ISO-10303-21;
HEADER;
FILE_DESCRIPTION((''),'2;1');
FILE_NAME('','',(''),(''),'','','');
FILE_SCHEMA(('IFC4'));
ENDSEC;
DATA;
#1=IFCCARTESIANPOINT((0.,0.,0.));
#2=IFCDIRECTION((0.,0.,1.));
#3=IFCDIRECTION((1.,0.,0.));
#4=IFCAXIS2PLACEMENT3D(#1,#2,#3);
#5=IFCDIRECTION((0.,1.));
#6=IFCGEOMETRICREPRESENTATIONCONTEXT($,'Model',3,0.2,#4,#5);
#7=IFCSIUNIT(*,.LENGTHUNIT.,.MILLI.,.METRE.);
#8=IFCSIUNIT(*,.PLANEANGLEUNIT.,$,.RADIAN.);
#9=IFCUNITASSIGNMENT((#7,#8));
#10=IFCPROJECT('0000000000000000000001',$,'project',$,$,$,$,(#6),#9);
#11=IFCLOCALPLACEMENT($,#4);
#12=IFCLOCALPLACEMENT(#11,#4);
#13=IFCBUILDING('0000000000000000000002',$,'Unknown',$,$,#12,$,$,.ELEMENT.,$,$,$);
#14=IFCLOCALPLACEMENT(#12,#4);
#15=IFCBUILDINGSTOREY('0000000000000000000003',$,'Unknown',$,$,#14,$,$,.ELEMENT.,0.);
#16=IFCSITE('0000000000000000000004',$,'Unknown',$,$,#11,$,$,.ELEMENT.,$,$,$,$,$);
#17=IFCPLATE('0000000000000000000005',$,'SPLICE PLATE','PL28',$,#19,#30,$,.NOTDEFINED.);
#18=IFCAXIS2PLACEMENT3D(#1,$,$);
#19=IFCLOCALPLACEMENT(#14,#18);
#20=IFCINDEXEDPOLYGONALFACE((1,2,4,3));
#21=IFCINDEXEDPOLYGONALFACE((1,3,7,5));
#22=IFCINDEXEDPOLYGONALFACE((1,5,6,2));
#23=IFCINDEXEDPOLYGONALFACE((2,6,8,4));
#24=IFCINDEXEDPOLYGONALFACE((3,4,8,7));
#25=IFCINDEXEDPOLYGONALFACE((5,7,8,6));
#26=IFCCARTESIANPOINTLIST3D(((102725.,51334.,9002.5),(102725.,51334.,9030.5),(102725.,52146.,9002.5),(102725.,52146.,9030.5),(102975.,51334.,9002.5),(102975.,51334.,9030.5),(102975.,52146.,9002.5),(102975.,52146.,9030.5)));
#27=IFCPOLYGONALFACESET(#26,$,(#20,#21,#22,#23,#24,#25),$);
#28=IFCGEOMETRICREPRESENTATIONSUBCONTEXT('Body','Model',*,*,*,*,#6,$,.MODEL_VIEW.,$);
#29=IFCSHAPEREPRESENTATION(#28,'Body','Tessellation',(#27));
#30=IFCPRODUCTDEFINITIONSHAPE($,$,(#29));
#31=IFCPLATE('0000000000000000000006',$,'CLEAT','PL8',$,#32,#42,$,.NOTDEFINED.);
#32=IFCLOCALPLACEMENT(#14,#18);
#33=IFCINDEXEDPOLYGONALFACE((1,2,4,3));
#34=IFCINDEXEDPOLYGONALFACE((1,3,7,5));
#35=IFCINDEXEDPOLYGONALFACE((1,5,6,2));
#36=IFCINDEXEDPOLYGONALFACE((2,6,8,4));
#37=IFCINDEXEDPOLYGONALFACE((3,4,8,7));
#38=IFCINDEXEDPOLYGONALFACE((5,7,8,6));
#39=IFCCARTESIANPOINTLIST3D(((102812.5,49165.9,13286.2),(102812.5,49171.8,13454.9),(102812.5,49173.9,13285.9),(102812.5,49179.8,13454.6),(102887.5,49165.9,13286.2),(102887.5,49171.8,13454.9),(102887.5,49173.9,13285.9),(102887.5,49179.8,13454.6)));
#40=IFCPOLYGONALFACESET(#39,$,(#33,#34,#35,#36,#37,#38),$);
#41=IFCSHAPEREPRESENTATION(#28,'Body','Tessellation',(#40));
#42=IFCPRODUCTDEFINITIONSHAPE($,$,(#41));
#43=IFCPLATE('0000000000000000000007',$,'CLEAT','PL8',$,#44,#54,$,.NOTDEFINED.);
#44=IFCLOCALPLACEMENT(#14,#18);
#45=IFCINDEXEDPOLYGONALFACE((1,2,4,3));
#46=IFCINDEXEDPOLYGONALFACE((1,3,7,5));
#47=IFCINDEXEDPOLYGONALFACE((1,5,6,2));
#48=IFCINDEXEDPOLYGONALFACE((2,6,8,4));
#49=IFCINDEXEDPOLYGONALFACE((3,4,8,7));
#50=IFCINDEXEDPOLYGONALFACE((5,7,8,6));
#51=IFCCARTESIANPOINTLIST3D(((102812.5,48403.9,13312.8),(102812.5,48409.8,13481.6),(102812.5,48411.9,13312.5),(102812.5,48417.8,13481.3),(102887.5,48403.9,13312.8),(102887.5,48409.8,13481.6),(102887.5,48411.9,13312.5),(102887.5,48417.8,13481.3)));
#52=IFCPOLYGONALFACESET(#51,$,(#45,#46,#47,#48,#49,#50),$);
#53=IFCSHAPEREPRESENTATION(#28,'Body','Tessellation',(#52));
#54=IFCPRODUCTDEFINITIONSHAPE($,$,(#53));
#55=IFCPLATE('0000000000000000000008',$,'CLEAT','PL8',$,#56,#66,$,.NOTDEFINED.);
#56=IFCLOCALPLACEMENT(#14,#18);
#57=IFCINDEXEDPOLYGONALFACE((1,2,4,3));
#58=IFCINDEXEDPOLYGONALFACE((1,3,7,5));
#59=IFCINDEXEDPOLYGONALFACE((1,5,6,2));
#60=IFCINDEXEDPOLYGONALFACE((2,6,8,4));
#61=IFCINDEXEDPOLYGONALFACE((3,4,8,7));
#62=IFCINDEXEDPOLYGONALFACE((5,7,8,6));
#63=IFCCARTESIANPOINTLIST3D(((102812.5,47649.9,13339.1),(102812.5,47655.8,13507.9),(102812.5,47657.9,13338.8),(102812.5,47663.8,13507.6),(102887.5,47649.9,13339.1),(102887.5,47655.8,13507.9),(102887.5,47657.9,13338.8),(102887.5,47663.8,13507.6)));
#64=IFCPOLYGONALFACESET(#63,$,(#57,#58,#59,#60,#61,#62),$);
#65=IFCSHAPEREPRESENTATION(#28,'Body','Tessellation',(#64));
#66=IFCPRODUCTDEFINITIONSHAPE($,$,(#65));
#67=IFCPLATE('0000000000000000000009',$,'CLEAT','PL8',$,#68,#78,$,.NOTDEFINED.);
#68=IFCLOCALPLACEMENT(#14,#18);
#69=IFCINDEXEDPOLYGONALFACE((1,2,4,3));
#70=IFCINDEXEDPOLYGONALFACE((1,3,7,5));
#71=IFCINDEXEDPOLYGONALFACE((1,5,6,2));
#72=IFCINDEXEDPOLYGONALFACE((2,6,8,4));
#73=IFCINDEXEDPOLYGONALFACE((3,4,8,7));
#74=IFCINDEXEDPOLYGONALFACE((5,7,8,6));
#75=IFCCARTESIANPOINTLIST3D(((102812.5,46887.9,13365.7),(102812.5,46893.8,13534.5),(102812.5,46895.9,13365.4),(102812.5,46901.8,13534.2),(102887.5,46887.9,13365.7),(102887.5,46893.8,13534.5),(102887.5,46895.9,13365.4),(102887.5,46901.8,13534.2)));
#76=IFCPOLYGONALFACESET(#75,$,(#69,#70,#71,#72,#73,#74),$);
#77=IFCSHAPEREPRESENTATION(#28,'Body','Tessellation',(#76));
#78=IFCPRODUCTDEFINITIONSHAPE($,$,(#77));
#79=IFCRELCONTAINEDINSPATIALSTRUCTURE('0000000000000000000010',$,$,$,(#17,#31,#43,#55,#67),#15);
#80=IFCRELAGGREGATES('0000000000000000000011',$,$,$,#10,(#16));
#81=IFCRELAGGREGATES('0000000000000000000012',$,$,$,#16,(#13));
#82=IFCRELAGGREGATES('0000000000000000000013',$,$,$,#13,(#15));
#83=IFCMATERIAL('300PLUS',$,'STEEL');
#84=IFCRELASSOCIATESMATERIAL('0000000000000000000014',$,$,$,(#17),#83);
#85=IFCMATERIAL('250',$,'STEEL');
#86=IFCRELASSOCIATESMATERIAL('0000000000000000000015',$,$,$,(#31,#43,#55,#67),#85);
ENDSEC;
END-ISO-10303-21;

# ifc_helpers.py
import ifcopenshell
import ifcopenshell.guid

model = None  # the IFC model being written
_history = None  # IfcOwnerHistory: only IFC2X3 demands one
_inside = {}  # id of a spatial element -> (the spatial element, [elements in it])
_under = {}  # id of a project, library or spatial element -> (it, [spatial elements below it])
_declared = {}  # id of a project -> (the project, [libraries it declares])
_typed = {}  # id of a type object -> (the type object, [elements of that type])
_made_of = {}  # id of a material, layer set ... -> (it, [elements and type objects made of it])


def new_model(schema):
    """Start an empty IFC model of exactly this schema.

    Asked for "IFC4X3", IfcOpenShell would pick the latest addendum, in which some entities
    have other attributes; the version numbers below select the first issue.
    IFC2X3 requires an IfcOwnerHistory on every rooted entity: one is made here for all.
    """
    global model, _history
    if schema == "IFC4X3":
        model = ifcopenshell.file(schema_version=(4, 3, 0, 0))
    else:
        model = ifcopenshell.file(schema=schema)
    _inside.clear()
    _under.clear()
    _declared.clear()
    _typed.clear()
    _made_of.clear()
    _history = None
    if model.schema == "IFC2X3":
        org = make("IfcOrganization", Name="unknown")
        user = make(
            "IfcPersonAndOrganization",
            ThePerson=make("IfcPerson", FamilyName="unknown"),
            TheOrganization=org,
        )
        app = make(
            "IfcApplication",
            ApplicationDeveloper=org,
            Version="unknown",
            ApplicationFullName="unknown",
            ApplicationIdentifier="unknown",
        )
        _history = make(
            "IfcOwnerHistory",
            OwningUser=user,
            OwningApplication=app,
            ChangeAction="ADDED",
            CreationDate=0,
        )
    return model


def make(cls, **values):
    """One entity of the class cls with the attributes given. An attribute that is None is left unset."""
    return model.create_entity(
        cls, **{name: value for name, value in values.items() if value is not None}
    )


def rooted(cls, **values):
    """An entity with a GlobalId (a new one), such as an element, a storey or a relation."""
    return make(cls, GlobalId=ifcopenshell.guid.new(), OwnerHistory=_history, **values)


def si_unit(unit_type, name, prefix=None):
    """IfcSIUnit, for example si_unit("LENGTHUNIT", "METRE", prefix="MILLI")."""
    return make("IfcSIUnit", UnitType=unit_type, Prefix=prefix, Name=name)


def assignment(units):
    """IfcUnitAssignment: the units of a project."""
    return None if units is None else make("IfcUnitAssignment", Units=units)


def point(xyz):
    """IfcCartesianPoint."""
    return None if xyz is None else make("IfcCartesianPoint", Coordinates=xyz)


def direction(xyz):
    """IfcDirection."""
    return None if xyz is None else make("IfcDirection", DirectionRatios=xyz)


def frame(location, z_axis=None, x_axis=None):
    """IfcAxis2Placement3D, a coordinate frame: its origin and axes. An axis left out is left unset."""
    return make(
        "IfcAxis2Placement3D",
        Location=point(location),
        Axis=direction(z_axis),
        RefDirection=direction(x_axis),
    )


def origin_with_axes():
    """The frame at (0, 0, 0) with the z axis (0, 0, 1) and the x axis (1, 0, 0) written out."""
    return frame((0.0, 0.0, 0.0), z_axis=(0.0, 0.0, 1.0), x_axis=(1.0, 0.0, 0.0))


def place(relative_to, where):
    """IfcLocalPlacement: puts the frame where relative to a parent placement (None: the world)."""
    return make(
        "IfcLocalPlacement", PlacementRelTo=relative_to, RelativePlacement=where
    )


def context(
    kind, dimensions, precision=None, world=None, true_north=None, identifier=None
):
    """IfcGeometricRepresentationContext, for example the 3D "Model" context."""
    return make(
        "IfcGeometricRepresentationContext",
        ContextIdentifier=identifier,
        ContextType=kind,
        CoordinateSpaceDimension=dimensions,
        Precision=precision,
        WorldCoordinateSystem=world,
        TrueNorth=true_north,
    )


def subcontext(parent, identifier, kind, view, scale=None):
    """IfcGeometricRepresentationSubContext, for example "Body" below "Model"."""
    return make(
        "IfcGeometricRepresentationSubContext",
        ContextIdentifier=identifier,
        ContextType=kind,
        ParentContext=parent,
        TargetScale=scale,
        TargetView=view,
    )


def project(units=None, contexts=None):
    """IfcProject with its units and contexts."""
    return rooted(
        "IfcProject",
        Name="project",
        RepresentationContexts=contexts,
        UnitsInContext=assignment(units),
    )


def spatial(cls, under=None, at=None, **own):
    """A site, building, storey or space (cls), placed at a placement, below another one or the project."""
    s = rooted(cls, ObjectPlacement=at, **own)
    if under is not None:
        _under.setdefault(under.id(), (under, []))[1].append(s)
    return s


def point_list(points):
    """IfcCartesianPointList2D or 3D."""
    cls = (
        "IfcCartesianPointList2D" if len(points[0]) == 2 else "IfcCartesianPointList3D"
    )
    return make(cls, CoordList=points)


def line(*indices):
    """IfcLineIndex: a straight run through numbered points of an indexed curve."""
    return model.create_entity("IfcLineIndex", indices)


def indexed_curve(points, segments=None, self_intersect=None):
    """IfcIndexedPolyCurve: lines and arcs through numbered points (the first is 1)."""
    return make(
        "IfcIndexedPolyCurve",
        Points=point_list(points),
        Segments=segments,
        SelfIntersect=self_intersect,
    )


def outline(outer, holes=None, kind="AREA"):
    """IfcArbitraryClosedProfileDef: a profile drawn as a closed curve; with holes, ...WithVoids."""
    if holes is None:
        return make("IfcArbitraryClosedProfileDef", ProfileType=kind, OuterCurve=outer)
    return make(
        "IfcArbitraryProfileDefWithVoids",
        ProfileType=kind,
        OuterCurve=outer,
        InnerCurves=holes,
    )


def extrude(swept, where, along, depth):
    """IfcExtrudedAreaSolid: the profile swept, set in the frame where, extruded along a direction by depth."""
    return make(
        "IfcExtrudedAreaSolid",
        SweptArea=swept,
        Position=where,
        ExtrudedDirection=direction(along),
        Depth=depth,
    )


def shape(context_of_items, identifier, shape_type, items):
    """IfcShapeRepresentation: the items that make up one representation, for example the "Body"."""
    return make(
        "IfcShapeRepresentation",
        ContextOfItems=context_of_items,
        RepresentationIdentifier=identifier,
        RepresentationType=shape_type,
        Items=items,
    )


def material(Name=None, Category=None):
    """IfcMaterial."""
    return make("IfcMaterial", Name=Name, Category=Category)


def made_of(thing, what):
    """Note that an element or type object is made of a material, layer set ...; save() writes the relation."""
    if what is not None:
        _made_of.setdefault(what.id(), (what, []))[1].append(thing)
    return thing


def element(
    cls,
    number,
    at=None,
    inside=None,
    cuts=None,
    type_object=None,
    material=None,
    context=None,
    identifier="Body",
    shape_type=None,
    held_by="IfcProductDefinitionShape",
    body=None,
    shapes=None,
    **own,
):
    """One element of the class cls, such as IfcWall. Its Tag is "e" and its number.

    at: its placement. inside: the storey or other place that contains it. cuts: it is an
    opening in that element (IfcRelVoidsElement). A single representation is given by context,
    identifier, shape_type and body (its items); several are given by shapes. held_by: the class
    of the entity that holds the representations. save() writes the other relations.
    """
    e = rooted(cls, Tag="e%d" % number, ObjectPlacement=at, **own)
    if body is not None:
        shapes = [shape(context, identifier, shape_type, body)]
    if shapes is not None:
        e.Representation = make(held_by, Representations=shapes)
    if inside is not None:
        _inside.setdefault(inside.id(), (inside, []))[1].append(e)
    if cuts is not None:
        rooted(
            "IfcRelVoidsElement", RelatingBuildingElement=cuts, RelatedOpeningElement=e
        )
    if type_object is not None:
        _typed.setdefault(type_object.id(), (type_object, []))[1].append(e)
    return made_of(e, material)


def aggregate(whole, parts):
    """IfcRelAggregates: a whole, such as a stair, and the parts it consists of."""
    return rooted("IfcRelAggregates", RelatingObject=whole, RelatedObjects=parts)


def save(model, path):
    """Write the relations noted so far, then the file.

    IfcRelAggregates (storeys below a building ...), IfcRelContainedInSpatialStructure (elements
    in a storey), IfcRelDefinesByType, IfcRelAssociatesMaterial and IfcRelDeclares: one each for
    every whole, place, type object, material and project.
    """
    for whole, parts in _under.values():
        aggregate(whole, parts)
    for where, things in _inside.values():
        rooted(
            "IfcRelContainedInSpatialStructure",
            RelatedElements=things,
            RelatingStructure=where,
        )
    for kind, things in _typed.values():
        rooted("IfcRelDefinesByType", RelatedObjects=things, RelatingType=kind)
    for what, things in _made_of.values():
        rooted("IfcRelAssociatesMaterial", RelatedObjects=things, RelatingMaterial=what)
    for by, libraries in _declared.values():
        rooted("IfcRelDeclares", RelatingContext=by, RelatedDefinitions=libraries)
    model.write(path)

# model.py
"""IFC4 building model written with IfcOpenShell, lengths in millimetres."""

from ifc_helpers import new_model, si_unit, direction, frame, origin_with_axes, place, context, subcontext, project, spatial, line, indexed_curve, outline, extrude, material, element, save


model = new_model("IFC4")

# Units and contexts
model_context = context("Model", 3, precision=0.2, world=origin_with_axes(), true_north=direction((0.0, 1.0)))
body_context = subcontext(model_context, "Body", "Model", "MODEL_VIEW")
ifc_project = project(units=[si_unit("LENGTHUNIT", "METRE", prefix="MILLI"), si_unit("PLANEANGLEUNIT", "RADIAN")], contexts=[model_context])

# Site, building, storey
site_placement = place(None, origin_with_axes())
site = spatial("IfcSite", under=ifc_project, at=site_placement, Name="Unknown", CompositionType="ELEMENT")
building_placement = place(site_placement, origin_with_axes())
building = spatial("IfcBuilding", under=site, at=building_placement, Name="Unknown", CompositionType="ELEMENT")
storey_placement = place(building_placement, origin_with_axes())
storey = spatial("IfcBuildingStorey", under=building, at=storey_placement, Name="Unknown", CompositionType="ELEMENT", Elevation=0.0)

# Shared definitions
ifc_material_1 = material(Name="300PLUS", Category="STEEL")

# Plates
ifc_material_2 = material(Name="250", Category="STEEL")
plate_1_placement = place(storey_placement, frame((102975.0, 51334.0, 9016.5), z_axis=(0.0, 0.0, 1.0), x_axis=(0.0, 1.0, 0.0)))
element("IfcPlate", 1, at=plate_1_placement, inside=storey, material=ifc_material_1, Name="SPLICE PLATE", Description="PL28", PredefinedType="NOTDEFINED", context=body_context, shape_type="SolidModel", body=[
    extrude(outline(indexed_curve([(0.0, 0.0), (812.0, 0.0), (812.0, 250.0), (0.0, 250.0)], segments=[line(1, 2, 3, 4, 1)])), frame((0.0, 0.0, 14.0), z_axis=(0.0, 0.0, 1.0), x_axis=(1.0, 0.0, 0.0)), (0.0, 0.0, -1.0), 28.0),
])
plate_2_placement = place(storey_placement, frame((102812.5, 49169.9, 13286.0), z_axis=(0.0, -0.999389, 0.034952), x_axis=(1.0, 0.0, 0.0)))
element("IfcPlate", 2, at=plate_2_placement, inside=storey, material=ifc_material_2, Name="CLEAT", Description="PL8", PredefinedType="NOTDEFINED", context=body_context, shape_type="SolidModel", body=[
    extrude(outline(indexed_curve([(0.0, 0.0), (75.0, 0.0), (75.0, 168.8), (0.0, 168.8)], segments=[line(1, 2, 3, 4, 1)])), frame((0.0, 0.0, 4.0), z_axis=(0.0, 0.0, 1.0), x_axis=(1.0, 0.0, 0.0)), (0.0, 0.0, -1.0), 8.0),
])
for number, where, z_axis, x_axis, name in (
    (3, (102812.5, 48407.9, 13312.6), (0.0, -0.99939, 0.034931), (1.0, 0.0, 0.0), "CLEAT"),
    (4, (102812.5, 47653.9, 13338.9), (0.0, -0.99939, 0.034931), (1.0, 0.0, 0.0), "CLEAT"),
    (5, (102812.5, 46891.9, 13365.5), (0.0, -0.99939, 0.034931), (1.0, 0.0, 0.0), "CLEAT"),
):
    element("IfcPlate", number, at=place(storey_placement, frame(where, z_axis=z_axis, x_axis=x_axis)), inside=storey, material=ifc_material_2, Name=name, Description="PL8", PredefinedType="NOTDEFINED", context=body_context, shape_type="SolidModel", body=[
        extrude(outline(indexed_curve([(0.0, 0.0), (75.0, 0.0), (75.0, 168.9), (0.0, 168.9)], segments=[line(1, 2, 3, 4, 1)])), frame((0.0, 0.0, 4.0), z_axis=(0.0, 0.0, 1.0), x_axis=(1.0, 0.0, 0.0)), (0.0, 0.0, -1.0), 8.0),
    ])

save(model, "model.ifc")
